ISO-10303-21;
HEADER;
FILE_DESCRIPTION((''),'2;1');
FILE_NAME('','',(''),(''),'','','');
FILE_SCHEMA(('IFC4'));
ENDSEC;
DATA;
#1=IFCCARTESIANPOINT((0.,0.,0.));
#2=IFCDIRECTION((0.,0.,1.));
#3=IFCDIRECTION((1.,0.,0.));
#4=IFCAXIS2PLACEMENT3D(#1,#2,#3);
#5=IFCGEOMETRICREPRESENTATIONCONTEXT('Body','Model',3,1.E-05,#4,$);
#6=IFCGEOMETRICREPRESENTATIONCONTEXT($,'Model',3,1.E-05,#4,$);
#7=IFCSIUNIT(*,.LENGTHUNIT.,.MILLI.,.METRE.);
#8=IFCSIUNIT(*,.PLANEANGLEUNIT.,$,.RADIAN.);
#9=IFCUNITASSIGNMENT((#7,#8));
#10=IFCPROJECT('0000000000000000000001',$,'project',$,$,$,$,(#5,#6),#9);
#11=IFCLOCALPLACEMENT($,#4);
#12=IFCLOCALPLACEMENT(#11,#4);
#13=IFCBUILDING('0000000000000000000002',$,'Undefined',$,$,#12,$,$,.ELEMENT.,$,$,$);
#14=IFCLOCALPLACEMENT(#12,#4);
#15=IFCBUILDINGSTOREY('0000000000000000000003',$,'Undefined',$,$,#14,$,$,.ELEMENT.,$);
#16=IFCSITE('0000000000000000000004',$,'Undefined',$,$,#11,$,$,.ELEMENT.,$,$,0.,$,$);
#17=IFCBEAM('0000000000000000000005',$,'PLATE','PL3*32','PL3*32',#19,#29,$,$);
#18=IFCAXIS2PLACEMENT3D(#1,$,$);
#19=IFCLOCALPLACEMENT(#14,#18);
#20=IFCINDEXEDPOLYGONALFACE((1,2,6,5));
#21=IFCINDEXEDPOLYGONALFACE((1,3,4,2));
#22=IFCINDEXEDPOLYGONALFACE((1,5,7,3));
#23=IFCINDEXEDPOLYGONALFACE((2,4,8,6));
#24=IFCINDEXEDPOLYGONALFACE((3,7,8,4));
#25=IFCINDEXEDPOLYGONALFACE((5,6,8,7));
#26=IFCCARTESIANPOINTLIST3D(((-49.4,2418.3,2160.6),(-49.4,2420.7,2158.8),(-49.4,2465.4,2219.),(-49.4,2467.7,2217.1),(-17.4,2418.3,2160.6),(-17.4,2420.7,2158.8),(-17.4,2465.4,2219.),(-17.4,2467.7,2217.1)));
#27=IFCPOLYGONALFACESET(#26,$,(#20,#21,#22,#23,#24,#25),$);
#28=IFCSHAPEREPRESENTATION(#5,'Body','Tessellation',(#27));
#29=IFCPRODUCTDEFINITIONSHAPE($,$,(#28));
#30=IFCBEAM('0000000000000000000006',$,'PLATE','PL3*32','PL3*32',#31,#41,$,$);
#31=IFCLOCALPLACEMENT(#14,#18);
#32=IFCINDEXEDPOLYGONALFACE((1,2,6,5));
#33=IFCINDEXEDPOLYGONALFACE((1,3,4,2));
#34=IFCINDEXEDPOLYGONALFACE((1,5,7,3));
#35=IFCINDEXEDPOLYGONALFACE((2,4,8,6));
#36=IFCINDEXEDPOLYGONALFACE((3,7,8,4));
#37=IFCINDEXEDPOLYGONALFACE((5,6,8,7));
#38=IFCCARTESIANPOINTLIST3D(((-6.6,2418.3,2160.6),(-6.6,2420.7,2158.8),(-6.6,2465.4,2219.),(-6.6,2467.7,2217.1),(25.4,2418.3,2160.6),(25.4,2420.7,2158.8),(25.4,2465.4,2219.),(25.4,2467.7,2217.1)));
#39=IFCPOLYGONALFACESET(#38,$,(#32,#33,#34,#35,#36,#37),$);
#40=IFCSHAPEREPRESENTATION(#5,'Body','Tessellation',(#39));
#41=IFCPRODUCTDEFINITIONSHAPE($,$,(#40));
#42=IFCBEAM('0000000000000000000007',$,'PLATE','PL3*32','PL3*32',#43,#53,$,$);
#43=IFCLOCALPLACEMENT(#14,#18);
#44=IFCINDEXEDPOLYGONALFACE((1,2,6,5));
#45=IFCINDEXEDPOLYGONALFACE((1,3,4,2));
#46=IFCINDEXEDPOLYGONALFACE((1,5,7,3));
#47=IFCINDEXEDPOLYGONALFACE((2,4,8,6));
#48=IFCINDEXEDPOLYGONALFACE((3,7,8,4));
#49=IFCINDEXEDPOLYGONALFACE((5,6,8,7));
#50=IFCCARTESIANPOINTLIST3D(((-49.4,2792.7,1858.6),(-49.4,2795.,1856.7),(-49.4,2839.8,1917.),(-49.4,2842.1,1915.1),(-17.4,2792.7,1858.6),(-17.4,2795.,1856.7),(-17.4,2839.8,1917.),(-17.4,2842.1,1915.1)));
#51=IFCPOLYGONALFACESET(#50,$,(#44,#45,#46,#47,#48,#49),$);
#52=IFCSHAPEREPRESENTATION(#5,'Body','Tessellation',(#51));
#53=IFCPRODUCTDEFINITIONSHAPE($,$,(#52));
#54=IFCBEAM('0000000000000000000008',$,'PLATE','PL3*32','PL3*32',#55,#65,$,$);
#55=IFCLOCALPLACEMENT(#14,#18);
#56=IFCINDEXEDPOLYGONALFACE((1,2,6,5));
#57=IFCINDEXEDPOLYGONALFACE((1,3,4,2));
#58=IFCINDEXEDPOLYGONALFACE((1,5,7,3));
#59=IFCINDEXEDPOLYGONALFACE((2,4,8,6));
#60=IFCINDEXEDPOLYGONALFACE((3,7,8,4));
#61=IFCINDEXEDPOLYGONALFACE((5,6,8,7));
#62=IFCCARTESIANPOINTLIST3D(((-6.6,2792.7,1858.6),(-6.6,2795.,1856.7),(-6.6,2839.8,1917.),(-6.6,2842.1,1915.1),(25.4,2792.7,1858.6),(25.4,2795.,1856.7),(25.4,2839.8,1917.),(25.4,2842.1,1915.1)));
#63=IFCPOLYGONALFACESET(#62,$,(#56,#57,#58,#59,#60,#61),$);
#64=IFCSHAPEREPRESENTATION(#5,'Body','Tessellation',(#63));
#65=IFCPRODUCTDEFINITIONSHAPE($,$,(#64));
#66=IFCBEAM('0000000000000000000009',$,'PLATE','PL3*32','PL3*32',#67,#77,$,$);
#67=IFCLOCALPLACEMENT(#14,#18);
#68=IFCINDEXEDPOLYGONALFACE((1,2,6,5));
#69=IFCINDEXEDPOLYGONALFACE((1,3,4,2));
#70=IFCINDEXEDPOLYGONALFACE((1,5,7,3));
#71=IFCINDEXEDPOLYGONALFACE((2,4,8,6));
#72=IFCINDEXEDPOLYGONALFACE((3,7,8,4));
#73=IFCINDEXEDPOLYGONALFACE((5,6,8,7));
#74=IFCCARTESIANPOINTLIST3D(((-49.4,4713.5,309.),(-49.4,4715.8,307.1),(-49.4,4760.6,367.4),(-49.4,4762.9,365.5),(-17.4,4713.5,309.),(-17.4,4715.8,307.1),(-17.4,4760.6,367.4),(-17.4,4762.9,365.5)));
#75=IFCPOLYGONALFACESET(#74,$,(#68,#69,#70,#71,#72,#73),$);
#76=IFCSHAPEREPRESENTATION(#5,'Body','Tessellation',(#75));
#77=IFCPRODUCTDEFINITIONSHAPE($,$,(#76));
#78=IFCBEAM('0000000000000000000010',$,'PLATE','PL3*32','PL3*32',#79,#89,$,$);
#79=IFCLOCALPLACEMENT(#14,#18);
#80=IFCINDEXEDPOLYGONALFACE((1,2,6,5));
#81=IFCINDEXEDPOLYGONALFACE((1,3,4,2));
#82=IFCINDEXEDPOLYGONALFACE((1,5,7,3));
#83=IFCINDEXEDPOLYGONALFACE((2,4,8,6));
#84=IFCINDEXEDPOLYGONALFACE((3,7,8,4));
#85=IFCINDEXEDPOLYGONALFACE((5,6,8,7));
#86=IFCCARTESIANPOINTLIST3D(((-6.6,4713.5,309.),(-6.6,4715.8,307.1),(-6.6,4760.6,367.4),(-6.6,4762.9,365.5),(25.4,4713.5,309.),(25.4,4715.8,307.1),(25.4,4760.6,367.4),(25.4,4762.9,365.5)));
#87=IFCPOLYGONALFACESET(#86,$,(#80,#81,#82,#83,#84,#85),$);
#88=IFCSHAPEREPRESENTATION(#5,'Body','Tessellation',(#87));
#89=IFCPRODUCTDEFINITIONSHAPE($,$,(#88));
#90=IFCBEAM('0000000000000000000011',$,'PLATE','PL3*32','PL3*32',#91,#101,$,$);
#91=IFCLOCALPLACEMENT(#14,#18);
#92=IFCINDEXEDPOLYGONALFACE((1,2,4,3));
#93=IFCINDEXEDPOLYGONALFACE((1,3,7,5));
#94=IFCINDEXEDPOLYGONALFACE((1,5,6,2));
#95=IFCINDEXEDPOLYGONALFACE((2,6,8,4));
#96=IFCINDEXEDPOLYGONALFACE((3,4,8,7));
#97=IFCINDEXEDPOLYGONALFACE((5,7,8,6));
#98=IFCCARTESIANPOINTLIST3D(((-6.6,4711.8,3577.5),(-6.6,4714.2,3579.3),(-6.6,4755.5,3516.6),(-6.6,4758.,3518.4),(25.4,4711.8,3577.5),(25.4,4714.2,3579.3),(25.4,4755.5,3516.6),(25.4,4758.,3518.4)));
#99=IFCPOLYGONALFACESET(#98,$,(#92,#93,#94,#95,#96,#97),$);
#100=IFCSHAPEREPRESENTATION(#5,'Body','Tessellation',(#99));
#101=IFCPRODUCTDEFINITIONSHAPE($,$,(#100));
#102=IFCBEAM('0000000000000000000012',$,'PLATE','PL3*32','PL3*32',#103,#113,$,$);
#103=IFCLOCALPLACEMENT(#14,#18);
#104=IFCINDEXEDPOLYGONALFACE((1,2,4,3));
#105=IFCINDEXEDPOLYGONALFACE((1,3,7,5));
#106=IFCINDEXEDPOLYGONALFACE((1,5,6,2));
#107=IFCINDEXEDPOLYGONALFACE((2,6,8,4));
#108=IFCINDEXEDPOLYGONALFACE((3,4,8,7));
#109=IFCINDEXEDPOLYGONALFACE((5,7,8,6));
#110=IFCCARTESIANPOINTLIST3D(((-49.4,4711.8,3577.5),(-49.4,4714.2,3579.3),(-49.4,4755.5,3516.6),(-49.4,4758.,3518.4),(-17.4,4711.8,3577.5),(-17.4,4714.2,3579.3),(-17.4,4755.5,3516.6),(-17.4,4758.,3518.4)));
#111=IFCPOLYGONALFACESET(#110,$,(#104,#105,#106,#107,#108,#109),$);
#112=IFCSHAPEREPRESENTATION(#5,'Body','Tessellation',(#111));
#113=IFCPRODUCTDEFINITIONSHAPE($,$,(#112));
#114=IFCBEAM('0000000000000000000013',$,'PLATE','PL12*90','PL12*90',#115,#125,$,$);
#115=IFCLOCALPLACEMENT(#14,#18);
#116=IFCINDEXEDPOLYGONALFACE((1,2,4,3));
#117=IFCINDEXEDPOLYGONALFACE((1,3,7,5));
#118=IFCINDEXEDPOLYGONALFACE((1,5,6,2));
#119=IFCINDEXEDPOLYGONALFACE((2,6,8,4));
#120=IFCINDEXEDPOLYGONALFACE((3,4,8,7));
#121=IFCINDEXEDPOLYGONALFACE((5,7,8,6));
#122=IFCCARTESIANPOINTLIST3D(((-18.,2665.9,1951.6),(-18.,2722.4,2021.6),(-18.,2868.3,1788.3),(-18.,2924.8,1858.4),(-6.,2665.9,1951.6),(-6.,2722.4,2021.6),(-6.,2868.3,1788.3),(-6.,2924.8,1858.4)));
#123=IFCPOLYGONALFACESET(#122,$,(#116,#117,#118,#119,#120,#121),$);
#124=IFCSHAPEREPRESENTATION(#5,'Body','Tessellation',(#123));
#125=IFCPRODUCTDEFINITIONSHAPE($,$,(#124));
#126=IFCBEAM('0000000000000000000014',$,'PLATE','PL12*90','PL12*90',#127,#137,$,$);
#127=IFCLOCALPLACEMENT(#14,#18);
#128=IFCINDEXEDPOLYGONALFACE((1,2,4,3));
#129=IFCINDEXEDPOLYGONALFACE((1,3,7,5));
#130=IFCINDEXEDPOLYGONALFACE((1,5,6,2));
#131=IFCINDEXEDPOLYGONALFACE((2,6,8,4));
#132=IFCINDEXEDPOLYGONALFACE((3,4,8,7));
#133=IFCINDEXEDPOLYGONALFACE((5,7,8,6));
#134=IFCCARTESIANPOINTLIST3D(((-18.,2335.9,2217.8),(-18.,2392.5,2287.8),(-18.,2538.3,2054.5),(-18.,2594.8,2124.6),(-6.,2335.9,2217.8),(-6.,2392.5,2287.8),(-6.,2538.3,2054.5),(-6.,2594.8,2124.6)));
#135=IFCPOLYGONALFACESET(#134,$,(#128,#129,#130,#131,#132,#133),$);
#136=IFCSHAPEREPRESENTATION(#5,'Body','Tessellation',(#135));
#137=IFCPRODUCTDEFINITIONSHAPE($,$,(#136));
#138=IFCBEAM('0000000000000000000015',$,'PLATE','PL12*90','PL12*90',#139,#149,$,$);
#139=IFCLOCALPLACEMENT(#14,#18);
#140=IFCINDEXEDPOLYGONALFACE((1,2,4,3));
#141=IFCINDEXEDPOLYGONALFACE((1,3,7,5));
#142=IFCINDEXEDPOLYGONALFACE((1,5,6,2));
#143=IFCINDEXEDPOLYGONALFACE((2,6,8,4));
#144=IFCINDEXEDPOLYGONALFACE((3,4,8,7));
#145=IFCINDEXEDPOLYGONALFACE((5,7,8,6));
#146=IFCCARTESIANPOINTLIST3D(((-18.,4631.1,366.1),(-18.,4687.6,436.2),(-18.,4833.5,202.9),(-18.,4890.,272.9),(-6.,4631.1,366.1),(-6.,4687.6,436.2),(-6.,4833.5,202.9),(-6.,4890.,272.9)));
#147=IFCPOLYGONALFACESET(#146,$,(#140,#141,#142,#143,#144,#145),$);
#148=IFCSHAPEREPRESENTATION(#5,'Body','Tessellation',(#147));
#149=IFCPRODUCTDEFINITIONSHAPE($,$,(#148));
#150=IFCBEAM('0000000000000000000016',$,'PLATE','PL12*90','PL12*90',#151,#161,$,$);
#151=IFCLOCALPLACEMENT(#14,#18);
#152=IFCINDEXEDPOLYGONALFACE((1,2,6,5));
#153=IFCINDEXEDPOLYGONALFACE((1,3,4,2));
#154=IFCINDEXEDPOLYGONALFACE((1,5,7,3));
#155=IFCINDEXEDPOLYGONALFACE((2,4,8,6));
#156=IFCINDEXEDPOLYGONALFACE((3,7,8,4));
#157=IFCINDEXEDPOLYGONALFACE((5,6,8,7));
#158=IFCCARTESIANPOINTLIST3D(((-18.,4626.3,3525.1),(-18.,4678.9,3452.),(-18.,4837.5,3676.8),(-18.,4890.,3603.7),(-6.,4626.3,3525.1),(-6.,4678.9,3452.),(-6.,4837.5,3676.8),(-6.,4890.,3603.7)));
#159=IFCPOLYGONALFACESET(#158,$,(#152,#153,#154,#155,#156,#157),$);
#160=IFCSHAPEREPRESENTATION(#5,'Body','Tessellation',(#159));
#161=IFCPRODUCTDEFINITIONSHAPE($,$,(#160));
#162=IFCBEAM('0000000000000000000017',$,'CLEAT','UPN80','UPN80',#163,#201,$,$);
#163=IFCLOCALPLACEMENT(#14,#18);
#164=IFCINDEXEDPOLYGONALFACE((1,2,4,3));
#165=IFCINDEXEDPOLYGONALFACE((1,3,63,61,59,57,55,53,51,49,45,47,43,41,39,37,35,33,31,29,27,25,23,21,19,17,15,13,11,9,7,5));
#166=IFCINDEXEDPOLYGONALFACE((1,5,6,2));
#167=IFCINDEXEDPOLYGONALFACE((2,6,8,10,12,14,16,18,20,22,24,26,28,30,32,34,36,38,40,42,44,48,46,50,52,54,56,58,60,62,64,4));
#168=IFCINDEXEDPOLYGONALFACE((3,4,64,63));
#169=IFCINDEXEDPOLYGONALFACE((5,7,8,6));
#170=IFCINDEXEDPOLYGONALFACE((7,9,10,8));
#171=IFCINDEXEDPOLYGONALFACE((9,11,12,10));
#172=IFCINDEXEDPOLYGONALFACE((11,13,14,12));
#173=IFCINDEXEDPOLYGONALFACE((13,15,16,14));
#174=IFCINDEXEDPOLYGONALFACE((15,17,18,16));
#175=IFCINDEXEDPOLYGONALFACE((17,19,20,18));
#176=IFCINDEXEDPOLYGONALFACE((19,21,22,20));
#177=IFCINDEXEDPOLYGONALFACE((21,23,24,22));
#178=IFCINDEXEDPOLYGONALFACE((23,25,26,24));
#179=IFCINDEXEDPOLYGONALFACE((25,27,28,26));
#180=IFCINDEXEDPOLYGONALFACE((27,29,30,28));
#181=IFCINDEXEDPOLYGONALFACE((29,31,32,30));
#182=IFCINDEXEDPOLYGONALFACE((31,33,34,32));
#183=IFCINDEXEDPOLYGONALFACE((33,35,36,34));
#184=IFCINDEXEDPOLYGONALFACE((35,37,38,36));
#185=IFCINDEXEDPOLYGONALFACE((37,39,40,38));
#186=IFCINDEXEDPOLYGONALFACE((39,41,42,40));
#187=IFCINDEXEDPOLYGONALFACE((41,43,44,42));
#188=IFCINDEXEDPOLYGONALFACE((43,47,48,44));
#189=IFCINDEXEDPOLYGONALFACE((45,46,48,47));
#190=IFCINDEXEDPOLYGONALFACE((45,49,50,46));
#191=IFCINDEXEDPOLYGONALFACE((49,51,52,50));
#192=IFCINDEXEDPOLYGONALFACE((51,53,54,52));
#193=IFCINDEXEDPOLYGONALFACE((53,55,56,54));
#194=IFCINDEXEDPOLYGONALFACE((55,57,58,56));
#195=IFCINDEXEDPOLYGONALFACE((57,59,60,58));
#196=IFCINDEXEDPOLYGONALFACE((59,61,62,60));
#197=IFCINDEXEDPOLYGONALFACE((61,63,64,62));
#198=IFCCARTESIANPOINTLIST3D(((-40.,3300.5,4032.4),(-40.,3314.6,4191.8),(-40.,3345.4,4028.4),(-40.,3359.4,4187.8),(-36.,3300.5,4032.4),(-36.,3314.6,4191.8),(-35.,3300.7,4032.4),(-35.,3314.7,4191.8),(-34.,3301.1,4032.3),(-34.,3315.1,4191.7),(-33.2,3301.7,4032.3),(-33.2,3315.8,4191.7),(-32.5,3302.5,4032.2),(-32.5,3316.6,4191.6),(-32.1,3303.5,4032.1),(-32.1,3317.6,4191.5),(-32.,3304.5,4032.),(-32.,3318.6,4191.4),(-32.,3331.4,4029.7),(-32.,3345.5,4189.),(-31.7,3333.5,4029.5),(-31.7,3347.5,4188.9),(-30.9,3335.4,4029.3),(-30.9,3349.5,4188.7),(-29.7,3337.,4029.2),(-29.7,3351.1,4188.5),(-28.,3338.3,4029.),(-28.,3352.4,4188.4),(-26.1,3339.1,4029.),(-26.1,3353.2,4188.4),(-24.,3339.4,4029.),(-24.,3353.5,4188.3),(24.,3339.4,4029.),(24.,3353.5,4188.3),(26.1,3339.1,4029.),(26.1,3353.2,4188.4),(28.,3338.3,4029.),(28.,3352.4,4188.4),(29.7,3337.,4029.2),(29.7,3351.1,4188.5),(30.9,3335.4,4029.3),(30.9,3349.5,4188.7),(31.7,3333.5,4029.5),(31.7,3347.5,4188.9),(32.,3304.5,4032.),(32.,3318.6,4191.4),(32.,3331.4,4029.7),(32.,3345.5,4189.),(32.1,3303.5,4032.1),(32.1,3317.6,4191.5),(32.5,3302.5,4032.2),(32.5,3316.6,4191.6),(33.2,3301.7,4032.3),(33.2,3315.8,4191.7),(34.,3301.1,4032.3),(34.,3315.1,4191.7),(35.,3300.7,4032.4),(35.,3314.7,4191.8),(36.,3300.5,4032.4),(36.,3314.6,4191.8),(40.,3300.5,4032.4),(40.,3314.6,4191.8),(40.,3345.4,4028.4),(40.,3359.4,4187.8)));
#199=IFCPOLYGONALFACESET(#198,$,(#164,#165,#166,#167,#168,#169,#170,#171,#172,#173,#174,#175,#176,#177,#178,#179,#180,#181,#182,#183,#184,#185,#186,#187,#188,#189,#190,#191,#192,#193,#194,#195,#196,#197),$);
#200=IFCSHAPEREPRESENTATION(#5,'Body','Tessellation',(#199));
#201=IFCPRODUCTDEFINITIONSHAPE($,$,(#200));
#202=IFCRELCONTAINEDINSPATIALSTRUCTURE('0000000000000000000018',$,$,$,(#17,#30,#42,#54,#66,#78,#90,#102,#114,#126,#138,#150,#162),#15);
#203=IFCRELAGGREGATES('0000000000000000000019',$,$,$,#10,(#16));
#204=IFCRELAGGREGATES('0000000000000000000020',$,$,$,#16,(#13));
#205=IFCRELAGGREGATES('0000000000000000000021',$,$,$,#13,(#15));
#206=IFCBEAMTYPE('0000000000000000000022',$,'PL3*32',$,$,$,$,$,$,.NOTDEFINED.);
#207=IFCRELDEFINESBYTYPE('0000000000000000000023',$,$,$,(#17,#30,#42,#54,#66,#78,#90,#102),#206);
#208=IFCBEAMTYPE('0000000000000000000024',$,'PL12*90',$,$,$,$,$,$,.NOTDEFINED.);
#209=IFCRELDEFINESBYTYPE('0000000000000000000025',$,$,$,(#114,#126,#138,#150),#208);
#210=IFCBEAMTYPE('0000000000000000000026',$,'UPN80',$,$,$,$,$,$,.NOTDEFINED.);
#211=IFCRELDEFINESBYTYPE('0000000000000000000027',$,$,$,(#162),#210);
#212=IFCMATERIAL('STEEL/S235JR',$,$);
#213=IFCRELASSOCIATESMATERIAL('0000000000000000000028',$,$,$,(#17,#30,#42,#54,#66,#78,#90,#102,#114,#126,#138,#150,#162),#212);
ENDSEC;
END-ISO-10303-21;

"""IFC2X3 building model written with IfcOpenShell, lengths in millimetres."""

from ifc_helpers import new_model, si_unit, frame, origin_with_axes, origin_2d_with_axis, place, context, project, spatial, rectangle, u_section, extrude, material, type_object, element, save


model = new_model("IFC2X3")

# Units and contexts
model_context_1 = context("Model", 3, precision=1e-05, world=origin_with_axes(), identifier="Body")
model_context_2 = context("Model", 3, precision=1e-05, world=origin_with_axes())
ifc_project = project(units=[si_unit("LENGTHUNIT", "METRE", prefix="MILLI"), si_unit("PLANEANGLEUNIT", "RADIAN")], contexts=[model_context_1, model_context_2])

# Site, building, storey
site_placement = place(None, origin_with_axes())
site = spatial("IfcSite", under=ifc_project, at=site_placement, Name="Undefined", CompositionType="ELEMENT", RefElevation=0.0)
building_placement = place(site_placement, origin_with_axes())
building = spatial("IfcBuilding", under=site, at=building_placement, Name="Undefined", CompositionType="ELEMENT")
storey_placement = place(building_placement, origin_with_axes())
storey = spatial("IfcBuildingStorey", under=building, at=storey_placement, Name="Undefined", CompositionType="ELEMENT")

# Shared definitions
ifc_material = material(Name="STEEL/S235JR")

# Beams
beam_type_1 = type_object("IfcBeamType", Name="PL3*32", PredefinedType="NOTDEFINED")
for number, where, z_axis, x_axis, name in (
    (1, (-33.4, 2466.6, 2218.1), (1.0, 0.0, 0.0), (0.0, -0.627936, -0.778265), "PLATE"),
    (2, (9.4, 2466.6, 2218.1), (-1.0, 0.0, 0.0), (0.0, -0.627936, -0.778265), "PLATE"),
):
    element("IfcBeam", number, at=place(storey_placement, frame(where, z_axis=z_axis, x_axis=x_axis)), inside=storey, type_object=beam_type_1, material=ifc_material, Name=name, Description="PL3*32", ObjectType="PL3*32", context=model_context_1, shape_type="SweptSolid", body=[
        extrude(rectangle(XDim=3.0, YDim=32.0, at=origin_2d_with_axis()), frame((75.0, 0.0, 0.0), z_axis=(-1.0, 0.0, 0.0), x_axis=(0.0, -1.0, 0.0)), (0.0, 0.0, 1.0), 75.0),
    ])
for number, where, z_axis, x_axis, name in (
    (3, (-33.4, 2840.9, 1916.1), (1.0, 0.0, 0.0), (0.0, -0.627936, -0.778265), "PLATE"),
    (4, (9.4, 2840.9, 1916.1), (-1.0, 0.0, 0.0), (0.0, -0.627936, -0.778265), "PLATE"),
):
    element("IfcBeam", number, at=place(storey_placement, frame(where, z_axis=z_axis, x_axis=x_axis)), inside=storey, type_object=beam_type_1, material=ifc_material, Name=name, Description="PL3*32", ObjectType="PL3*32", context=model_context_1, shape_type="SweptSolid", body=[
        extrude(rectangle(XDim=3.0, YDim=32.0, at=origin_2d_with_axis()), frame((75.0, 0.0, 0.0), z_axis=(-1.0, 0.0, 0.0), x_axis=(0.0, -1.0, 0.0)), (0.0, 0.0, 1.0), 75.0),
    ])
for number, where, z_axis, x_axis, name in (
    (5, (-33.4, 4761.8, 366.4), (1.0, 0.0, 0.0), (0.0, -0.627936, -0.778265), "PLATE"),
    (6, (9.4, 4761.8, 366.4), (-1.0, 0.0, 0.0), (0.0, -0.627936, -0.778265), "PLATE"),
):
    element("IfcBeam", number, at=place(storey_placement, frame(where, z_axis=z_axis, x_axis=x_axis)), inside=storey, type_object=beam_type_1, material=ifc_material, Name=name, Description="PL3*32", ObjectType="PL3*32", context=model_context_1, shape_type="SweptSolid", body=[
        extrude(rectangle(XDim=3.0, YDim=32.0, at=origin_2d_with_axis()), frame((75.0, 0.0, 0.0), z_axis=(-1.0, 0.0, 0.0), x_axis=(0.0, -1.0, 0.0)), (0.0, 0.0, 1.0), 75.0),
    ])
for number, where, z_axis, x_axis, name in (
    (7, (9.4, 4756.8, 3517.5), (-1.0, 0.0, 0.0), (0.0, -0.583503, 0.812111), "PLATE"),
    (8, (-33.4, 4756.8, 3517.5), (1.0, 0.0, 0.0), (0.0, -0.583503, 0.812111), "PLATE"),
):
    element("IfcBeam", number, at=place(storey_placement, frame(where, z_axis=z_axis, x_axis=x_axis)), inside=storey, type_object=beam_type_1, material=ifc_material, Name=name, Description="PL3*32", ObjectType="PL3*32", context=model_context_1, shape_type="SweptSolid", body=[
        extrude(rectangle(XDim=3.0, YDim=32.0, at=origin_2d_with_axis()), frame((75.0, 0.0, 0.0), z_axis=(-1.0, 0.0, 0.0), x_axis=(0.0, -1.0, 0.0)), (0.0, 0.0, 1.0), 75.0),
    ])
beam_type_2 = type_object("IfcBeamType", Name="PL12*90", PredefinedType="NOTDEFINED")
for number, where, z_axis, x_axis, name in (
    (9, (-12.0, 2694.2, 1986.6), (0.0, 0.627892, 0.7783), (0.0, 0.7783, -0.627892), "PLATE"),
    (10, (-12.0, 2566.6, 2089.6), (0.0, 0.627892, 0.7783), (0.0, -0.7783, 0.627892), "PLATE"),
):
    element("IfcBeam", number, at=place(storey_placement, frame(where, z_axis=z_axis, x_axis=x_axis)), inside=storey, type_object=beam_type_2, material=ifc_material, Name=name, Description="PL12*90", ObjectType="PL12*90", context=model_context_1, shape_type="SweptSolid", body=[
        extrude(rectangle(XDim=12.0, YDim=90.0, at=origin_2d_with_axis()), frame((260.0, 0.0, 0.0), z_axis=(-1.0, 0.0, 0.0), x_axis=(0.0, -1.0, 0.0)), (0.0, 0.0, 1.0), 260.0),
    ])
beam_1_placement = place(storey_placement, frame((-12.0, 4861.7, 237.9), z_axis=(0.0, -0.627907, -0.778288), x_axis=(0.0, -0.778288, 0.627907)))
element("IfcBeam", 11, at=beam_1_placement, inside=storey, type_object=beam_type_2, material=ifc_material, Name="PLATE", Description="PL12*90", ObjectType="PL12*90", context=model_context_1, shape_type="SweptSolid", body=[
    extrude(rectangle(XDim=12.0, YDim=90.0, at=origin_2d_with_axis()), frame((260.0, 0.0, 0.0), z_axis=(-1.0, 0.0, 0.0), x_axis=(0.0, -1.0, 0.0)), (0.0, 0.0, 1.0), 260.0),
])
beam_2_placement = place(storey_placement, frame((-12.0, 4863.7, 3640.2), z_axis=(0.0, -0.583503, 0.812111), x_axis=(0.0, -0.812111, -0.583503)))
element("IfcBeam", 12, at=beam_2_placement, inside=storey, type_object=beam_type_2, material=ifc_material, Name="PLATE", Description="PL12*90", ObjectType="PL12*90", context=model_context_1, shape_type="SweptSolid", body=[
    extrude(rectangle(XDim=12.0, YDim=90.0, at=origin_2d_with_axis()), frame((260.0, 0.0, 0.0), z_axis=(-1.0, 0.0, 0.0), x_axis=(0.0, -1.0, 0.0)), (0.0, 0.0, 1.0), 260.0),
])
beam_type_3 = type_object("IfcBeamType", Name="UPN80", PredefinedType="NOTDEFINED")
for number, where, z_axis, x_axis, name in (
    (13, (0.0, 3322.9, 4030.4), (-1.0, 0.0, 0.0), (0.0, 0.08801, 0.99612), "CLEAT"),
):
    element("IfcBeam", number, at=place(storey_placement, frame(where, z_axis=z_axis, x_axis=x_axis)), inside=storey, type_object=beam_type_3, material=ifc_material, Name=name, Description="UPN80", ObjectType="UPN80", context=model_context_1, shape_type="SweptSolid", body=[
        extrude(u_section(Depth=80.0, FlangeWidth=45.0, WebThickness=6.0, FlangeThickness=8.0, FilletRadius=8.0, EdgeRadius=4.0, at=origin_2d_with_axis()), frame((160.0, 0.0, 0.0), z_axis=(-1.0, 0.0, 0.0), x_axis=(0.0, -1.0, 0.0)), (0.0, 0.0, 1.0), 160.0),
    ])

save(model, "model.ifc")
